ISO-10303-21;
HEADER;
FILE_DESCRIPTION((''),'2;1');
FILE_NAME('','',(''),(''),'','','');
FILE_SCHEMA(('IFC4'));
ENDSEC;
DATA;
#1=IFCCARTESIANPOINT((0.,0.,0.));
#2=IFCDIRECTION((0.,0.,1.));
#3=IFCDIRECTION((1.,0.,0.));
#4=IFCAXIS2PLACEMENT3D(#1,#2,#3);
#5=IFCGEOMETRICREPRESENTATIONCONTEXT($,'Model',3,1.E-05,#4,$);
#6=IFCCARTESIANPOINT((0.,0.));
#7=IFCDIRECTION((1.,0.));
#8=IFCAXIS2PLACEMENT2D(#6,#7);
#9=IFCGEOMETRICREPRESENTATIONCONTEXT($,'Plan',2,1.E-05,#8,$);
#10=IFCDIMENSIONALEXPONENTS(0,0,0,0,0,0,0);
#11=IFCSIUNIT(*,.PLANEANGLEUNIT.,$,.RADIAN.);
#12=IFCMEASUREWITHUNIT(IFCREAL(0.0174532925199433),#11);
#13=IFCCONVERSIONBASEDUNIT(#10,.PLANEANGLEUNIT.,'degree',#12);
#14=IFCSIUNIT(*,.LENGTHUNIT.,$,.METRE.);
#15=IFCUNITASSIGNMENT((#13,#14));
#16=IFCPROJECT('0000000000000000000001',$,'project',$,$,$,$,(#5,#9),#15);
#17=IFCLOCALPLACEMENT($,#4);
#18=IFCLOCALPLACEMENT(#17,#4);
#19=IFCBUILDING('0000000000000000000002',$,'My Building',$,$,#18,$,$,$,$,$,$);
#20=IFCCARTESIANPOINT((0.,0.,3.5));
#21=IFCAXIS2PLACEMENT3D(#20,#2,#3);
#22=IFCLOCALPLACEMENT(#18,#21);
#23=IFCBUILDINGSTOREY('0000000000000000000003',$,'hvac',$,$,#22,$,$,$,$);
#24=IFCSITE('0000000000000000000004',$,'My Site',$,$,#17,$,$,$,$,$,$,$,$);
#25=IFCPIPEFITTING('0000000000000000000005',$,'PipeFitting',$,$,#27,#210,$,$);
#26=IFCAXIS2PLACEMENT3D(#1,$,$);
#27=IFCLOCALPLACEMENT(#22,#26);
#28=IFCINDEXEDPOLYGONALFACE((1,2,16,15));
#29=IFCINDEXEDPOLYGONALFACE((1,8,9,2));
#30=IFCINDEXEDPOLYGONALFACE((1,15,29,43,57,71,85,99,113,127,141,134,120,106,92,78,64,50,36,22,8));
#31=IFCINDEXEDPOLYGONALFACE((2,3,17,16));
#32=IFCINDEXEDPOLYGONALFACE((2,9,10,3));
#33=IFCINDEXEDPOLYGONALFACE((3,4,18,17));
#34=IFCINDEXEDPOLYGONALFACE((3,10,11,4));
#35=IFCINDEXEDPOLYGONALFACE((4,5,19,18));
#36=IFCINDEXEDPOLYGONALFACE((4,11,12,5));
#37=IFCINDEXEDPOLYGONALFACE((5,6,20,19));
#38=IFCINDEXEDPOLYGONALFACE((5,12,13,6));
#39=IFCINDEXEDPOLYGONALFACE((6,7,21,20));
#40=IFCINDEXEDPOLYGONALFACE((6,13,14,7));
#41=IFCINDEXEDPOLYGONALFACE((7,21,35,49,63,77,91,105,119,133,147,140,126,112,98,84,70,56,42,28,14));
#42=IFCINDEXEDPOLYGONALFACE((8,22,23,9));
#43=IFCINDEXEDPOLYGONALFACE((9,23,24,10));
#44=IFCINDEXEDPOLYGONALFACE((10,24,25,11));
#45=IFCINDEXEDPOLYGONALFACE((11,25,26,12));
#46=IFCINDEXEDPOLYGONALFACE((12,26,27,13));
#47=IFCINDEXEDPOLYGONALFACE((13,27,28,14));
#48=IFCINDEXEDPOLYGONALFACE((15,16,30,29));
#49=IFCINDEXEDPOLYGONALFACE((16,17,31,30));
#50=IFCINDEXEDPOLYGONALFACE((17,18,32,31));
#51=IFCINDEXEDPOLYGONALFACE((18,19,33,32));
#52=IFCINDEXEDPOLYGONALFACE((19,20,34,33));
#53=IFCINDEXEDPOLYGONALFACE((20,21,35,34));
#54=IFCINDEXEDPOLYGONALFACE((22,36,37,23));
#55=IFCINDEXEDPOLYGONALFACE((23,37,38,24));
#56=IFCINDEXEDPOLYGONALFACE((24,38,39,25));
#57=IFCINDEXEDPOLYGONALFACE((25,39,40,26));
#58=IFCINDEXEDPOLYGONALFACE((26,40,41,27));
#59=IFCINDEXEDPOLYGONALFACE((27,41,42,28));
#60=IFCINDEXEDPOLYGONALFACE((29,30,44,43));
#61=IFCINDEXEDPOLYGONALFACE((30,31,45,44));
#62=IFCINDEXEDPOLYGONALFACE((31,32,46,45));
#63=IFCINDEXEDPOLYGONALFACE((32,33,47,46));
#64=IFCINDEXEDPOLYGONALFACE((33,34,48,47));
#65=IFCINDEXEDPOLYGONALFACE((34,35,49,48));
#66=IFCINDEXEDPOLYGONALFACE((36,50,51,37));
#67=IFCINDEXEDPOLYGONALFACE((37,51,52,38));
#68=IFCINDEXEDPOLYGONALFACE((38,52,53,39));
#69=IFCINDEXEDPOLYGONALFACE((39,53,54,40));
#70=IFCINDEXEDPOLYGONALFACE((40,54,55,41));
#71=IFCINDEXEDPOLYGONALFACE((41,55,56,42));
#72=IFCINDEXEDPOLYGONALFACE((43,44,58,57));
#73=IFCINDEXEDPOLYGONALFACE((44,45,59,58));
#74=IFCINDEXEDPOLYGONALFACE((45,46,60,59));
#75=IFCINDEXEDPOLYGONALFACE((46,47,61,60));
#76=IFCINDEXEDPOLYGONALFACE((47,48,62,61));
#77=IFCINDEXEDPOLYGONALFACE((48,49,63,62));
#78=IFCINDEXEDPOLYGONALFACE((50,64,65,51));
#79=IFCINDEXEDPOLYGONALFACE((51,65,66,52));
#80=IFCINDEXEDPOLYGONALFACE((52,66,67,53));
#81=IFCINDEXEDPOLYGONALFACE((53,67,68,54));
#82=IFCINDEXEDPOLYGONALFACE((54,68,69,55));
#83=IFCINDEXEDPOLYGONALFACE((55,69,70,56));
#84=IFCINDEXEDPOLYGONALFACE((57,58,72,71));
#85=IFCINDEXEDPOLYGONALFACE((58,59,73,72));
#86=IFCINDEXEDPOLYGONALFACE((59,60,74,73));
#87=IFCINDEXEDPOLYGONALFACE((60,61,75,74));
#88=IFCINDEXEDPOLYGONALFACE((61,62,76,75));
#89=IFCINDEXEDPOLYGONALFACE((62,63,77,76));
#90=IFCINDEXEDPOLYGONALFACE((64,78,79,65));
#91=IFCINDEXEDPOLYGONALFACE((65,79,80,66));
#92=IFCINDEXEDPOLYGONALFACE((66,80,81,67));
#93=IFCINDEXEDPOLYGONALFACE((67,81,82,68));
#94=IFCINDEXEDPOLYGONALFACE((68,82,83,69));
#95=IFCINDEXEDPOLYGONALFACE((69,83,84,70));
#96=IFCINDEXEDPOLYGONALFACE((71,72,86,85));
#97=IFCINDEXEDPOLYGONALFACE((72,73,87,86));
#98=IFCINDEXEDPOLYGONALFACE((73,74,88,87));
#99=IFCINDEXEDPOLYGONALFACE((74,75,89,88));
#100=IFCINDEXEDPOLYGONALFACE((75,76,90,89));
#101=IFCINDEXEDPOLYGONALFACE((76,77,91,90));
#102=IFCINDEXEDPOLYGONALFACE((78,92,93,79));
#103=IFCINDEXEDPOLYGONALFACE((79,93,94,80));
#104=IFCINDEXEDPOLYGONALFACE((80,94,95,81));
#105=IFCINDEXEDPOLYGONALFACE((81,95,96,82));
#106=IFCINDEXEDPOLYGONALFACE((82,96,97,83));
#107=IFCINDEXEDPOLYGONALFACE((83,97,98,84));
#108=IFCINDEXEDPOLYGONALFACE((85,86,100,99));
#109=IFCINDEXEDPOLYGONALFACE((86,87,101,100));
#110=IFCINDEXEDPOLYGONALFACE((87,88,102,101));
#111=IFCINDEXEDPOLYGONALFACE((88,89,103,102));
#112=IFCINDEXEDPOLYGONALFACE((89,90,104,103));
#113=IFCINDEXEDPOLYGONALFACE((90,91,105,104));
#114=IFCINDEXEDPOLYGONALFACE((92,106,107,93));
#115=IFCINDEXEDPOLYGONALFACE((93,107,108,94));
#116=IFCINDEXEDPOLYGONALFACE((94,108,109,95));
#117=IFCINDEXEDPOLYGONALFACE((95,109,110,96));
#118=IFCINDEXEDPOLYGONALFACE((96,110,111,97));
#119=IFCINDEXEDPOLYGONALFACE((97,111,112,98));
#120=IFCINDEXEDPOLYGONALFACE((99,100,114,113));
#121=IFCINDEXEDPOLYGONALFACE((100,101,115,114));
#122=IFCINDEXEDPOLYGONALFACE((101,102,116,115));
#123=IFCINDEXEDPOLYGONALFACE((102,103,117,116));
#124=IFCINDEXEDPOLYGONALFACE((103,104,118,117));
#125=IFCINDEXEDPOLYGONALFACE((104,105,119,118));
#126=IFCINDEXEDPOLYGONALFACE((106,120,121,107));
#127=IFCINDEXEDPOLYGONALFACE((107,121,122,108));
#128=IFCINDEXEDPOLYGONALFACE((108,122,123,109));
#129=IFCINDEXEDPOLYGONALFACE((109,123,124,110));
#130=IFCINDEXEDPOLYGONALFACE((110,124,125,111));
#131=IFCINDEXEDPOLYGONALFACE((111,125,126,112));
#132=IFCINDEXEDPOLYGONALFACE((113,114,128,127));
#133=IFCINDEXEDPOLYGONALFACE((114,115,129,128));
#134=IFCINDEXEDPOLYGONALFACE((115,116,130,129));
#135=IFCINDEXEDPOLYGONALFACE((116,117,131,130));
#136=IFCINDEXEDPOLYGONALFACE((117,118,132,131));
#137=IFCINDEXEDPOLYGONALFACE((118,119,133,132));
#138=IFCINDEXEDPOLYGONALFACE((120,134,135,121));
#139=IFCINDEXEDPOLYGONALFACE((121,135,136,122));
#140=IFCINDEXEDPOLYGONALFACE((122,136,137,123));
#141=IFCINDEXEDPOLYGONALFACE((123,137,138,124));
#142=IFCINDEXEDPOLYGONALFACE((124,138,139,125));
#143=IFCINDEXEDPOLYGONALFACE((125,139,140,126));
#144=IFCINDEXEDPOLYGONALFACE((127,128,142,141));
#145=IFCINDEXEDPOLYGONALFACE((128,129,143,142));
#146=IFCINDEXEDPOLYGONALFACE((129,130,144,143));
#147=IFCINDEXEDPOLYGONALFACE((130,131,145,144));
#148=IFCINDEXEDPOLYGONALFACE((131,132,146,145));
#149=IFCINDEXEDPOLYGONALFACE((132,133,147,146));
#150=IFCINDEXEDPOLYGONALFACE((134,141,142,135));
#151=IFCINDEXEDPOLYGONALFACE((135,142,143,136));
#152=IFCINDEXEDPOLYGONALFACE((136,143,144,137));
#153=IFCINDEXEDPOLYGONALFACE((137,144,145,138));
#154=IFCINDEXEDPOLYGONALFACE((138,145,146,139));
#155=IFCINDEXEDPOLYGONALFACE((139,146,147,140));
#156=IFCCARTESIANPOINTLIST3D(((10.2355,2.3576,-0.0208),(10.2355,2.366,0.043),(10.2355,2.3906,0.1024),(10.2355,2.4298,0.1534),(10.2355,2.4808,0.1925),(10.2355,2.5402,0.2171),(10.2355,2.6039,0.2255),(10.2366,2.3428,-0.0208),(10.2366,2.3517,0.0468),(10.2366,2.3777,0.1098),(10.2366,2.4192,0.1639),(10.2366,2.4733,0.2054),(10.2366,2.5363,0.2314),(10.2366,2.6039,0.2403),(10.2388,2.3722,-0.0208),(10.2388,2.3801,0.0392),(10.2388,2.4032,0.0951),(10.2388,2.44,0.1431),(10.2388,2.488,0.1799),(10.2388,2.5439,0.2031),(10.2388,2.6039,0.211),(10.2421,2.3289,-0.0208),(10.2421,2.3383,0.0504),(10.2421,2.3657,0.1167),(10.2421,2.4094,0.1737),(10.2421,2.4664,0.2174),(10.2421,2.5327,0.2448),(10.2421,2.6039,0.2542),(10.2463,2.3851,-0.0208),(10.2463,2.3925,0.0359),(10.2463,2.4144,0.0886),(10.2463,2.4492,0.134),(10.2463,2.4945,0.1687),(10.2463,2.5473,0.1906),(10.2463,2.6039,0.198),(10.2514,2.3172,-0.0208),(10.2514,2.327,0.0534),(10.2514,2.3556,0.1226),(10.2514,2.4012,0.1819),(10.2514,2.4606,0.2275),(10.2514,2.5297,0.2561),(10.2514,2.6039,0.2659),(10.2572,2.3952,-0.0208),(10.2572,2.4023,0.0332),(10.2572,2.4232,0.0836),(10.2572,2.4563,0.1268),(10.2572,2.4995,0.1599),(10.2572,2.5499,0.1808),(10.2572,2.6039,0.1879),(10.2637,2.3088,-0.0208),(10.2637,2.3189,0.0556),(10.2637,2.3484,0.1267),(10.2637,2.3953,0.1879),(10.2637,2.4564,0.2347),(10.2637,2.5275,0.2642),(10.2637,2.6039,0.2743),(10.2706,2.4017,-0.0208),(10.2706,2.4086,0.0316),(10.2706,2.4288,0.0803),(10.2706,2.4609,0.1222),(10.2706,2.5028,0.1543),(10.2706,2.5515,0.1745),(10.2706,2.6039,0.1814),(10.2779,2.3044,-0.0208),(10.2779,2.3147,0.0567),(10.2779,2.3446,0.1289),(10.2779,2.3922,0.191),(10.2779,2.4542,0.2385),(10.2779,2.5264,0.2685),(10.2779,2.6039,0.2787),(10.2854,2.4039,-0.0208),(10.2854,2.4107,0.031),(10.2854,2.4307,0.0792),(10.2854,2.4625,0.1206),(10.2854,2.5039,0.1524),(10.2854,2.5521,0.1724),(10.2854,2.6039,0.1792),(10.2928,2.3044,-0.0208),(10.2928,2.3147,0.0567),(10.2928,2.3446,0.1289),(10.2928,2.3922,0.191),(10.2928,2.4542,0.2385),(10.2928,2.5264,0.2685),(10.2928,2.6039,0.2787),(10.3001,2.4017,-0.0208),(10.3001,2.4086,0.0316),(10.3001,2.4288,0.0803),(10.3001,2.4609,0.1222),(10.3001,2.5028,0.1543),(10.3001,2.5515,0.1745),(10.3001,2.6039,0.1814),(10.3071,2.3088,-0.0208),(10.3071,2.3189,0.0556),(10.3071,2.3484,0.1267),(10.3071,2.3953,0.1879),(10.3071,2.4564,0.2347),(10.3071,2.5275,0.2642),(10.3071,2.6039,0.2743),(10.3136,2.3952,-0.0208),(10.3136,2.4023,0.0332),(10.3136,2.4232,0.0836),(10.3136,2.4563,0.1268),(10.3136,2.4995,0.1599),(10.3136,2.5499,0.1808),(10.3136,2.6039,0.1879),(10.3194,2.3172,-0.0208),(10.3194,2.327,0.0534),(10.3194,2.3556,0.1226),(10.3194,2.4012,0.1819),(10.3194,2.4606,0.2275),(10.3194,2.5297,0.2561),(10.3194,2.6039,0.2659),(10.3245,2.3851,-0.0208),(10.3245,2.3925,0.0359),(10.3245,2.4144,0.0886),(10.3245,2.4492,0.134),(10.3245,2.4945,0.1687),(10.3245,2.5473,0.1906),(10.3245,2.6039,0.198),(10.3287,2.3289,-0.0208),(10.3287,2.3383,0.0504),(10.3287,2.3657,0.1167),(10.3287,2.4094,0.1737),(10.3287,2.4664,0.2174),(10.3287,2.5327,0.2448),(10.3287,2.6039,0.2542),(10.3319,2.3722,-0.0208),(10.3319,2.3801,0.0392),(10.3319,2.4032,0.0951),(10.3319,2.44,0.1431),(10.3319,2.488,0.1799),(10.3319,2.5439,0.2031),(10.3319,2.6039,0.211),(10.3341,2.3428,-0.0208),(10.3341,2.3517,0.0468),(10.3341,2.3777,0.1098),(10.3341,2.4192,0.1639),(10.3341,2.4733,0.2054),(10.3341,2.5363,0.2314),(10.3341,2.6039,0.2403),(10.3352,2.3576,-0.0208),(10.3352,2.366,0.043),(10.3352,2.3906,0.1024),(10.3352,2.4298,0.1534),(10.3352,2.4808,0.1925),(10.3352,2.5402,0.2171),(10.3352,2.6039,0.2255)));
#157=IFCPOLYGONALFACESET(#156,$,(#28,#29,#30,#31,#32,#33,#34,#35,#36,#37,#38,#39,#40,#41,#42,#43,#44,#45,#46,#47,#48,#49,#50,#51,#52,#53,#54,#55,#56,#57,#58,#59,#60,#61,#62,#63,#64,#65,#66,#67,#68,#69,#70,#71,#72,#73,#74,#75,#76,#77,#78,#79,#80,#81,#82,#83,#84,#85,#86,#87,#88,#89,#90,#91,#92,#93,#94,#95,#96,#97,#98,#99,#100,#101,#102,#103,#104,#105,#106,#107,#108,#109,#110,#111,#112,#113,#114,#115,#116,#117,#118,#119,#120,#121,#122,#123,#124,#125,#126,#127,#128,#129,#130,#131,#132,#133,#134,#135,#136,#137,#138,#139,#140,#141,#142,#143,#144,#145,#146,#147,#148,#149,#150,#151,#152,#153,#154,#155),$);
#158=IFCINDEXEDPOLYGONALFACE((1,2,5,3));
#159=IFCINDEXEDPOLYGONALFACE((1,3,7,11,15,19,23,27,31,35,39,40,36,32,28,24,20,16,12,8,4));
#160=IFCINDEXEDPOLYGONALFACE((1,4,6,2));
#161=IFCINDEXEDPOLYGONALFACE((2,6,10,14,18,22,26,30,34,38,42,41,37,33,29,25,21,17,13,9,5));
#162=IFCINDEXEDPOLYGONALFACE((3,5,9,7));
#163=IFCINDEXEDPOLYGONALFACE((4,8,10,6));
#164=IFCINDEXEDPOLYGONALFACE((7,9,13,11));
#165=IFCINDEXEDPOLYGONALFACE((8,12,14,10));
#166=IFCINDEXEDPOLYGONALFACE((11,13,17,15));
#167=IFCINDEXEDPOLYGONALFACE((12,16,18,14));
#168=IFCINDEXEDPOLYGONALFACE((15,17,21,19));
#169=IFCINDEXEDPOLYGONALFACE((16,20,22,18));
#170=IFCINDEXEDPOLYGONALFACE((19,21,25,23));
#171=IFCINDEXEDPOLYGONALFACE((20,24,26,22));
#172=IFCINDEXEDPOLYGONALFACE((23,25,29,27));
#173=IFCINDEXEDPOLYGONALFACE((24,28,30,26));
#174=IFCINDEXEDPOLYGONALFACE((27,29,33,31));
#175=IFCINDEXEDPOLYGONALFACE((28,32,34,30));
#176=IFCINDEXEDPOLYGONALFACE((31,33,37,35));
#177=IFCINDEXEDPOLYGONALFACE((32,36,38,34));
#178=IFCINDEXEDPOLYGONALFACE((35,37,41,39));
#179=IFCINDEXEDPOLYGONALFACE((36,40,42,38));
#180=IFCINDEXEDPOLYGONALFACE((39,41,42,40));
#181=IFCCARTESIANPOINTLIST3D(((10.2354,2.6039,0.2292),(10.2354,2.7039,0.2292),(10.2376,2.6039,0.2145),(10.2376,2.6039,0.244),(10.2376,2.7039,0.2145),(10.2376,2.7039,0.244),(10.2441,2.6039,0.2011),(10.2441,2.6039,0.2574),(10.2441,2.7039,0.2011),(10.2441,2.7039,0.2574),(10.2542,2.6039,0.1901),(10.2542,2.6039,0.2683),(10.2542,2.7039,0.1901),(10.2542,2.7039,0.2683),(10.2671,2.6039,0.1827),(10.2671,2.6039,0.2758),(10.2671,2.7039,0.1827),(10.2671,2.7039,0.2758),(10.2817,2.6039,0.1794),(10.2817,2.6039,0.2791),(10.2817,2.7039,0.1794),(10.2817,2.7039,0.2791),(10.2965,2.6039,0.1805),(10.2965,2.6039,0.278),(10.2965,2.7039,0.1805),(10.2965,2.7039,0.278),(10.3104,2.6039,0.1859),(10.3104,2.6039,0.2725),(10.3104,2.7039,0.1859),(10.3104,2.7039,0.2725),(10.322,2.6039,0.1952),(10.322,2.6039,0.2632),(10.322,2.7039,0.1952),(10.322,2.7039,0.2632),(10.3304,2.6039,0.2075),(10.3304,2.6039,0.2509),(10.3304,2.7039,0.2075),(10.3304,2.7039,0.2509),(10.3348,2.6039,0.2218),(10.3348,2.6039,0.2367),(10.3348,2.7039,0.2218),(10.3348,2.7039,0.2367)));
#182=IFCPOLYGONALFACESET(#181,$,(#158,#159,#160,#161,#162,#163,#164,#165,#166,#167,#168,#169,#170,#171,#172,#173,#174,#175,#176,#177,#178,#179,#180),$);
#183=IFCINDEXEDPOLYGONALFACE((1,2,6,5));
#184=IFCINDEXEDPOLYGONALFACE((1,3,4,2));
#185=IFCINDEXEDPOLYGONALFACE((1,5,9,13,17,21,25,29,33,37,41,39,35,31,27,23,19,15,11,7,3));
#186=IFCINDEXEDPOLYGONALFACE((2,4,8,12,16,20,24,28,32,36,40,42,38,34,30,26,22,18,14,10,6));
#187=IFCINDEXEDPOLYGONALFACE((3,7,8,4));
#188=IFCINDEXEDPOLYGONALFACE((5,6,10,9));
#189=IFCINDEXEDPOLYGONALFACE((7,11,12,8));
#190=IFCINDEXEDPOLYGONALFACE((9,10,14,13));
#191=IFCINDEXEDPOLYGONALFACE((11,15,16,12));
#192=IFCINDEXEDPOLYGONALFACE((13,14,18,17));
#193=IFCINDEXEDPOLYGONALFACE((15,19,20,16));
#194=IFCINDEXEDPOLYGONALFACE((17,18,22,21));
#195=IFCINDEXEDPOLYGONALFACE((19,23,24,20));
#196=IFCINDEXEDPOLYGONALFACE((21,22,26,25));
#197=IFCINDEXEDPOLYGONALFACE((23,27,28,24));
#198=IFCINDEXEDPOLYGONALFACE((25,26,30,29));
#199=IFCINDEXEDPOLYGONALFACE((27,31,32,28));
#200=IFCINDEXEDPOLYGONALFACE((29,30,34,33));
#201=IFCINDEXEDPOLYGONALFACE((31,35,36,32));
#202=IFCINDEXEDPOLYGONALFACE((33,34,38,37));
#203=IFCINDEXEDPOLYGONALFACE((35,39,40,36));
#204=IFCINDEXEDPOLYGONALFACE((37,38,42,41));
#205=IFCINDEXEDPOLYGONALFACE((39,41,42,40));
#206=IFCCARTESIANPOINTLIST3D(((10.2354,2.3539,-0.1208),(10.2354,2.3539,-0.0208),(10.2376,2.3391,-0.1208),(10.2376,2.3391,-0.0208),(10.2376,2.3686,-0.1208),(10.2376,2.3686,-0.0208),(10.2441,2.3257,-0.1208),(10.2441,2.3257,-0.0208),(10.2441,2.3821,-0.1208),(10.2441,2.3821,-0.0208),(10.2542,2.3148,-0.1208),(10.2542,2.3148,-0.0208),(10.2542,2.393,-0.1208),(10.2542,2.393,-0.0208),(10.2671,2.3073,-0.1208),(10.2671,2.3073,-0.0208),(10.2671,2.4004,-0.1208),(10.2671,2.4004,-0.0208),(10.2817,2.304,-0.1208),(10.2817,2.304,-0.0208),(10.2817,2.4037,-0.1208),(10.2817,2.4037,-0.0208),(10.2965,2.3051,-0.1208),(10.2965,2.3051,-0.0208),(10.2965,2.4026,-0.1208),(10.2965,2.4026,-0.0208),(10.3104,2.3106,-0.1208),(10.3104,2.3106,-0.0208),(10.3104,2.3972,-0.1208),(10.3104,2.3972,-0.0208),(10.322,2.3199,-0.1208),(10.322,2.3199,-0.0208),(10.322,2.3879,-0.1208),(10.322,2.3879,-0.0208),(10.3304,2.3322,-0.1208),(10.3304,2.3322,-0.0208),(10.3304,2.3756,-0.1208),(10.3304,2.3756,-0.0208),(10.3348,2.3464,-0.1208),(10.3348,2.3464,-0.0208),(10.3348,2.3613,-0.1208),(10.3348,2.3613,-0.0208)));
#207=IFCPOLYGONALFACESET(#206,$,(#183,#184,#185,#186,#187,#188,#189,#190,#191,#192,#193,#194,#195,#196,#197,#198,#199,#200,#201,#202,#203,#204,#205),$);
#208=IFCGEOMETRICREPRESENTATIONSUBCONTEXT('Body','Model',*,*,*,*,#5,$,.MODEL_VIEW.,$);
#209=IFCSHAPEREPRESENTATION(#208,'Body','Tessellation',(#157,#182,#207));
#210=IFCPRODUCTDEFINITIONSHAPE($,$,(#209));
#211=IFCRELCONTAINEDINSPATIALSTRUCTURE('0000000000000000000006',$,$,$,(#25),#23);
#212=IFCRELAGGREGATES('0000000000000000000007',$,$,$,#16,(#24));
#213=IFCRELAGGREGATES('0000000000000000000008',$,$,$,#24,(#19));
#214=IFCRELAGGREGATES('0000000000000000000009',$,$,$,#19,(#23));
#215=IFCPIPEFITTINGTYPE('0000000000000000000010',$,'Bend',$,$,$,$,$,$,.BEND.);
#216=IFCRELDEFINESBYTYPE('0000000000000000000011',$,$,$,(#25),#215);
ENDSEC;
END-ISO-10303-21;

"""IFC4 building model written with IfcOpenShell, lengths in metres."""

from ifc_helpers import new_model, entity, si_unit, converted_unit, frame, origin_with_axes, origin_2d_with_axis, place, context, subcontext, project, spatial, circle, extrude, source, transform, mapped, type_object, type_shapes, element, save


model = new_model("IFC4")

# Units and contexts
model_context = context("Model", 3, precision=1e-05, world=origin_with_axes())
plan_context = context("Plan", 2, precision=1e-05, world=origin_2d_with_axis())
body_context_1 = subcontext(model_context, "Body", "Model", "MODEL_VIEW")
ifc_project = project(units=[converted_unit("PLANEANGLEUNIT", "degree", entity("IfcReal", 0.0174532925199433), si_unit("PLANEANGLEUNIT", "RADIAN"), dimensions=[0, 0, 0, 0, 0, 0, 0]), si_unit("LENGTHUNIT", "METRE")], contexts=[model_context, plan_context])

# Site, building, storey
site_placement = place(None, origin_with_axes())
site = spatial("IfcSite", under=ifc_project, at=site_placement, Name="My Site")
building_placement = place(site_placement, origin_with_axes())
building = spatial("IfcBuilding", under=site, at=building_placement, Name="My Building")
storey_placement = place(building_placement, frame((0.0, 0.0, 3.5), z_axis=(0.0, 0.0, 1.0), x_axis=(1.0, 0.0, 0.0)))
storey = spatial("IfcBuildingStorey", under=building, at=storey_placement, Name="hvac")

# Pipe fitting
pipe_fitting_type = type_object("IfcPipeFittingType", Name="Bend", PredefinedType="BEND")
shared_shape_1 = source(origin_with_axes(), body_context_1, "Body", "SolidModel", [
    entity("IfcSweptDiskSolid", entity("IfcIndexedPolyCurve", entity("IfcCartesianPointList3D", [[0.0, 0.0, -0.1], [0.0, -0.0732, -0.2768], [0.0, -0.25, -0.35]]), [entity("IfcArcIndex", [1, 2, 3])]), 0.05),
    extrude(circle(Radius=0.05), origin_with_axes(), (0.0, 0.0, -1.0), 0.1),
    extrude(circle(Radius=0.05), frame((0.0, -0.25, -0.35), z_axis=(0.0, -1.0, -0.000032), x_axis=(1.0, 0.0, 0.0)), (0.0, 0.0, 1.0), 0.1),
])
type_shapes(pipe_fitting_type, [shared_shape_1])
for number, where, z_axis, x_axis, name in (
    (1, (10.2854, 2.7039, 0.2292), (0.0, 1.0, 0.0), (-1.0, 0.0, 0.0), "PipeFitting"),
):
    element("IfcPipeFitting", number, at=place(storey_placement, frame(where, z_axis=z_axis, x_axis=x_axis)), inside=storey, type_object=pipe_fitting_type, Name=name, context=body_context_1, shape_type="MappedRepresentation", body=[
        mapped(shared_shape_1, transform((0.0, 0.0, 0.0), x_axis=(1.0, 0.0, 0.0), y_axis=(0.0, 1.0, 0.0), z_axis=(0.0, 0.0, 1.0), scale=1.0)),
    ])

save(model, "model.ifc")
